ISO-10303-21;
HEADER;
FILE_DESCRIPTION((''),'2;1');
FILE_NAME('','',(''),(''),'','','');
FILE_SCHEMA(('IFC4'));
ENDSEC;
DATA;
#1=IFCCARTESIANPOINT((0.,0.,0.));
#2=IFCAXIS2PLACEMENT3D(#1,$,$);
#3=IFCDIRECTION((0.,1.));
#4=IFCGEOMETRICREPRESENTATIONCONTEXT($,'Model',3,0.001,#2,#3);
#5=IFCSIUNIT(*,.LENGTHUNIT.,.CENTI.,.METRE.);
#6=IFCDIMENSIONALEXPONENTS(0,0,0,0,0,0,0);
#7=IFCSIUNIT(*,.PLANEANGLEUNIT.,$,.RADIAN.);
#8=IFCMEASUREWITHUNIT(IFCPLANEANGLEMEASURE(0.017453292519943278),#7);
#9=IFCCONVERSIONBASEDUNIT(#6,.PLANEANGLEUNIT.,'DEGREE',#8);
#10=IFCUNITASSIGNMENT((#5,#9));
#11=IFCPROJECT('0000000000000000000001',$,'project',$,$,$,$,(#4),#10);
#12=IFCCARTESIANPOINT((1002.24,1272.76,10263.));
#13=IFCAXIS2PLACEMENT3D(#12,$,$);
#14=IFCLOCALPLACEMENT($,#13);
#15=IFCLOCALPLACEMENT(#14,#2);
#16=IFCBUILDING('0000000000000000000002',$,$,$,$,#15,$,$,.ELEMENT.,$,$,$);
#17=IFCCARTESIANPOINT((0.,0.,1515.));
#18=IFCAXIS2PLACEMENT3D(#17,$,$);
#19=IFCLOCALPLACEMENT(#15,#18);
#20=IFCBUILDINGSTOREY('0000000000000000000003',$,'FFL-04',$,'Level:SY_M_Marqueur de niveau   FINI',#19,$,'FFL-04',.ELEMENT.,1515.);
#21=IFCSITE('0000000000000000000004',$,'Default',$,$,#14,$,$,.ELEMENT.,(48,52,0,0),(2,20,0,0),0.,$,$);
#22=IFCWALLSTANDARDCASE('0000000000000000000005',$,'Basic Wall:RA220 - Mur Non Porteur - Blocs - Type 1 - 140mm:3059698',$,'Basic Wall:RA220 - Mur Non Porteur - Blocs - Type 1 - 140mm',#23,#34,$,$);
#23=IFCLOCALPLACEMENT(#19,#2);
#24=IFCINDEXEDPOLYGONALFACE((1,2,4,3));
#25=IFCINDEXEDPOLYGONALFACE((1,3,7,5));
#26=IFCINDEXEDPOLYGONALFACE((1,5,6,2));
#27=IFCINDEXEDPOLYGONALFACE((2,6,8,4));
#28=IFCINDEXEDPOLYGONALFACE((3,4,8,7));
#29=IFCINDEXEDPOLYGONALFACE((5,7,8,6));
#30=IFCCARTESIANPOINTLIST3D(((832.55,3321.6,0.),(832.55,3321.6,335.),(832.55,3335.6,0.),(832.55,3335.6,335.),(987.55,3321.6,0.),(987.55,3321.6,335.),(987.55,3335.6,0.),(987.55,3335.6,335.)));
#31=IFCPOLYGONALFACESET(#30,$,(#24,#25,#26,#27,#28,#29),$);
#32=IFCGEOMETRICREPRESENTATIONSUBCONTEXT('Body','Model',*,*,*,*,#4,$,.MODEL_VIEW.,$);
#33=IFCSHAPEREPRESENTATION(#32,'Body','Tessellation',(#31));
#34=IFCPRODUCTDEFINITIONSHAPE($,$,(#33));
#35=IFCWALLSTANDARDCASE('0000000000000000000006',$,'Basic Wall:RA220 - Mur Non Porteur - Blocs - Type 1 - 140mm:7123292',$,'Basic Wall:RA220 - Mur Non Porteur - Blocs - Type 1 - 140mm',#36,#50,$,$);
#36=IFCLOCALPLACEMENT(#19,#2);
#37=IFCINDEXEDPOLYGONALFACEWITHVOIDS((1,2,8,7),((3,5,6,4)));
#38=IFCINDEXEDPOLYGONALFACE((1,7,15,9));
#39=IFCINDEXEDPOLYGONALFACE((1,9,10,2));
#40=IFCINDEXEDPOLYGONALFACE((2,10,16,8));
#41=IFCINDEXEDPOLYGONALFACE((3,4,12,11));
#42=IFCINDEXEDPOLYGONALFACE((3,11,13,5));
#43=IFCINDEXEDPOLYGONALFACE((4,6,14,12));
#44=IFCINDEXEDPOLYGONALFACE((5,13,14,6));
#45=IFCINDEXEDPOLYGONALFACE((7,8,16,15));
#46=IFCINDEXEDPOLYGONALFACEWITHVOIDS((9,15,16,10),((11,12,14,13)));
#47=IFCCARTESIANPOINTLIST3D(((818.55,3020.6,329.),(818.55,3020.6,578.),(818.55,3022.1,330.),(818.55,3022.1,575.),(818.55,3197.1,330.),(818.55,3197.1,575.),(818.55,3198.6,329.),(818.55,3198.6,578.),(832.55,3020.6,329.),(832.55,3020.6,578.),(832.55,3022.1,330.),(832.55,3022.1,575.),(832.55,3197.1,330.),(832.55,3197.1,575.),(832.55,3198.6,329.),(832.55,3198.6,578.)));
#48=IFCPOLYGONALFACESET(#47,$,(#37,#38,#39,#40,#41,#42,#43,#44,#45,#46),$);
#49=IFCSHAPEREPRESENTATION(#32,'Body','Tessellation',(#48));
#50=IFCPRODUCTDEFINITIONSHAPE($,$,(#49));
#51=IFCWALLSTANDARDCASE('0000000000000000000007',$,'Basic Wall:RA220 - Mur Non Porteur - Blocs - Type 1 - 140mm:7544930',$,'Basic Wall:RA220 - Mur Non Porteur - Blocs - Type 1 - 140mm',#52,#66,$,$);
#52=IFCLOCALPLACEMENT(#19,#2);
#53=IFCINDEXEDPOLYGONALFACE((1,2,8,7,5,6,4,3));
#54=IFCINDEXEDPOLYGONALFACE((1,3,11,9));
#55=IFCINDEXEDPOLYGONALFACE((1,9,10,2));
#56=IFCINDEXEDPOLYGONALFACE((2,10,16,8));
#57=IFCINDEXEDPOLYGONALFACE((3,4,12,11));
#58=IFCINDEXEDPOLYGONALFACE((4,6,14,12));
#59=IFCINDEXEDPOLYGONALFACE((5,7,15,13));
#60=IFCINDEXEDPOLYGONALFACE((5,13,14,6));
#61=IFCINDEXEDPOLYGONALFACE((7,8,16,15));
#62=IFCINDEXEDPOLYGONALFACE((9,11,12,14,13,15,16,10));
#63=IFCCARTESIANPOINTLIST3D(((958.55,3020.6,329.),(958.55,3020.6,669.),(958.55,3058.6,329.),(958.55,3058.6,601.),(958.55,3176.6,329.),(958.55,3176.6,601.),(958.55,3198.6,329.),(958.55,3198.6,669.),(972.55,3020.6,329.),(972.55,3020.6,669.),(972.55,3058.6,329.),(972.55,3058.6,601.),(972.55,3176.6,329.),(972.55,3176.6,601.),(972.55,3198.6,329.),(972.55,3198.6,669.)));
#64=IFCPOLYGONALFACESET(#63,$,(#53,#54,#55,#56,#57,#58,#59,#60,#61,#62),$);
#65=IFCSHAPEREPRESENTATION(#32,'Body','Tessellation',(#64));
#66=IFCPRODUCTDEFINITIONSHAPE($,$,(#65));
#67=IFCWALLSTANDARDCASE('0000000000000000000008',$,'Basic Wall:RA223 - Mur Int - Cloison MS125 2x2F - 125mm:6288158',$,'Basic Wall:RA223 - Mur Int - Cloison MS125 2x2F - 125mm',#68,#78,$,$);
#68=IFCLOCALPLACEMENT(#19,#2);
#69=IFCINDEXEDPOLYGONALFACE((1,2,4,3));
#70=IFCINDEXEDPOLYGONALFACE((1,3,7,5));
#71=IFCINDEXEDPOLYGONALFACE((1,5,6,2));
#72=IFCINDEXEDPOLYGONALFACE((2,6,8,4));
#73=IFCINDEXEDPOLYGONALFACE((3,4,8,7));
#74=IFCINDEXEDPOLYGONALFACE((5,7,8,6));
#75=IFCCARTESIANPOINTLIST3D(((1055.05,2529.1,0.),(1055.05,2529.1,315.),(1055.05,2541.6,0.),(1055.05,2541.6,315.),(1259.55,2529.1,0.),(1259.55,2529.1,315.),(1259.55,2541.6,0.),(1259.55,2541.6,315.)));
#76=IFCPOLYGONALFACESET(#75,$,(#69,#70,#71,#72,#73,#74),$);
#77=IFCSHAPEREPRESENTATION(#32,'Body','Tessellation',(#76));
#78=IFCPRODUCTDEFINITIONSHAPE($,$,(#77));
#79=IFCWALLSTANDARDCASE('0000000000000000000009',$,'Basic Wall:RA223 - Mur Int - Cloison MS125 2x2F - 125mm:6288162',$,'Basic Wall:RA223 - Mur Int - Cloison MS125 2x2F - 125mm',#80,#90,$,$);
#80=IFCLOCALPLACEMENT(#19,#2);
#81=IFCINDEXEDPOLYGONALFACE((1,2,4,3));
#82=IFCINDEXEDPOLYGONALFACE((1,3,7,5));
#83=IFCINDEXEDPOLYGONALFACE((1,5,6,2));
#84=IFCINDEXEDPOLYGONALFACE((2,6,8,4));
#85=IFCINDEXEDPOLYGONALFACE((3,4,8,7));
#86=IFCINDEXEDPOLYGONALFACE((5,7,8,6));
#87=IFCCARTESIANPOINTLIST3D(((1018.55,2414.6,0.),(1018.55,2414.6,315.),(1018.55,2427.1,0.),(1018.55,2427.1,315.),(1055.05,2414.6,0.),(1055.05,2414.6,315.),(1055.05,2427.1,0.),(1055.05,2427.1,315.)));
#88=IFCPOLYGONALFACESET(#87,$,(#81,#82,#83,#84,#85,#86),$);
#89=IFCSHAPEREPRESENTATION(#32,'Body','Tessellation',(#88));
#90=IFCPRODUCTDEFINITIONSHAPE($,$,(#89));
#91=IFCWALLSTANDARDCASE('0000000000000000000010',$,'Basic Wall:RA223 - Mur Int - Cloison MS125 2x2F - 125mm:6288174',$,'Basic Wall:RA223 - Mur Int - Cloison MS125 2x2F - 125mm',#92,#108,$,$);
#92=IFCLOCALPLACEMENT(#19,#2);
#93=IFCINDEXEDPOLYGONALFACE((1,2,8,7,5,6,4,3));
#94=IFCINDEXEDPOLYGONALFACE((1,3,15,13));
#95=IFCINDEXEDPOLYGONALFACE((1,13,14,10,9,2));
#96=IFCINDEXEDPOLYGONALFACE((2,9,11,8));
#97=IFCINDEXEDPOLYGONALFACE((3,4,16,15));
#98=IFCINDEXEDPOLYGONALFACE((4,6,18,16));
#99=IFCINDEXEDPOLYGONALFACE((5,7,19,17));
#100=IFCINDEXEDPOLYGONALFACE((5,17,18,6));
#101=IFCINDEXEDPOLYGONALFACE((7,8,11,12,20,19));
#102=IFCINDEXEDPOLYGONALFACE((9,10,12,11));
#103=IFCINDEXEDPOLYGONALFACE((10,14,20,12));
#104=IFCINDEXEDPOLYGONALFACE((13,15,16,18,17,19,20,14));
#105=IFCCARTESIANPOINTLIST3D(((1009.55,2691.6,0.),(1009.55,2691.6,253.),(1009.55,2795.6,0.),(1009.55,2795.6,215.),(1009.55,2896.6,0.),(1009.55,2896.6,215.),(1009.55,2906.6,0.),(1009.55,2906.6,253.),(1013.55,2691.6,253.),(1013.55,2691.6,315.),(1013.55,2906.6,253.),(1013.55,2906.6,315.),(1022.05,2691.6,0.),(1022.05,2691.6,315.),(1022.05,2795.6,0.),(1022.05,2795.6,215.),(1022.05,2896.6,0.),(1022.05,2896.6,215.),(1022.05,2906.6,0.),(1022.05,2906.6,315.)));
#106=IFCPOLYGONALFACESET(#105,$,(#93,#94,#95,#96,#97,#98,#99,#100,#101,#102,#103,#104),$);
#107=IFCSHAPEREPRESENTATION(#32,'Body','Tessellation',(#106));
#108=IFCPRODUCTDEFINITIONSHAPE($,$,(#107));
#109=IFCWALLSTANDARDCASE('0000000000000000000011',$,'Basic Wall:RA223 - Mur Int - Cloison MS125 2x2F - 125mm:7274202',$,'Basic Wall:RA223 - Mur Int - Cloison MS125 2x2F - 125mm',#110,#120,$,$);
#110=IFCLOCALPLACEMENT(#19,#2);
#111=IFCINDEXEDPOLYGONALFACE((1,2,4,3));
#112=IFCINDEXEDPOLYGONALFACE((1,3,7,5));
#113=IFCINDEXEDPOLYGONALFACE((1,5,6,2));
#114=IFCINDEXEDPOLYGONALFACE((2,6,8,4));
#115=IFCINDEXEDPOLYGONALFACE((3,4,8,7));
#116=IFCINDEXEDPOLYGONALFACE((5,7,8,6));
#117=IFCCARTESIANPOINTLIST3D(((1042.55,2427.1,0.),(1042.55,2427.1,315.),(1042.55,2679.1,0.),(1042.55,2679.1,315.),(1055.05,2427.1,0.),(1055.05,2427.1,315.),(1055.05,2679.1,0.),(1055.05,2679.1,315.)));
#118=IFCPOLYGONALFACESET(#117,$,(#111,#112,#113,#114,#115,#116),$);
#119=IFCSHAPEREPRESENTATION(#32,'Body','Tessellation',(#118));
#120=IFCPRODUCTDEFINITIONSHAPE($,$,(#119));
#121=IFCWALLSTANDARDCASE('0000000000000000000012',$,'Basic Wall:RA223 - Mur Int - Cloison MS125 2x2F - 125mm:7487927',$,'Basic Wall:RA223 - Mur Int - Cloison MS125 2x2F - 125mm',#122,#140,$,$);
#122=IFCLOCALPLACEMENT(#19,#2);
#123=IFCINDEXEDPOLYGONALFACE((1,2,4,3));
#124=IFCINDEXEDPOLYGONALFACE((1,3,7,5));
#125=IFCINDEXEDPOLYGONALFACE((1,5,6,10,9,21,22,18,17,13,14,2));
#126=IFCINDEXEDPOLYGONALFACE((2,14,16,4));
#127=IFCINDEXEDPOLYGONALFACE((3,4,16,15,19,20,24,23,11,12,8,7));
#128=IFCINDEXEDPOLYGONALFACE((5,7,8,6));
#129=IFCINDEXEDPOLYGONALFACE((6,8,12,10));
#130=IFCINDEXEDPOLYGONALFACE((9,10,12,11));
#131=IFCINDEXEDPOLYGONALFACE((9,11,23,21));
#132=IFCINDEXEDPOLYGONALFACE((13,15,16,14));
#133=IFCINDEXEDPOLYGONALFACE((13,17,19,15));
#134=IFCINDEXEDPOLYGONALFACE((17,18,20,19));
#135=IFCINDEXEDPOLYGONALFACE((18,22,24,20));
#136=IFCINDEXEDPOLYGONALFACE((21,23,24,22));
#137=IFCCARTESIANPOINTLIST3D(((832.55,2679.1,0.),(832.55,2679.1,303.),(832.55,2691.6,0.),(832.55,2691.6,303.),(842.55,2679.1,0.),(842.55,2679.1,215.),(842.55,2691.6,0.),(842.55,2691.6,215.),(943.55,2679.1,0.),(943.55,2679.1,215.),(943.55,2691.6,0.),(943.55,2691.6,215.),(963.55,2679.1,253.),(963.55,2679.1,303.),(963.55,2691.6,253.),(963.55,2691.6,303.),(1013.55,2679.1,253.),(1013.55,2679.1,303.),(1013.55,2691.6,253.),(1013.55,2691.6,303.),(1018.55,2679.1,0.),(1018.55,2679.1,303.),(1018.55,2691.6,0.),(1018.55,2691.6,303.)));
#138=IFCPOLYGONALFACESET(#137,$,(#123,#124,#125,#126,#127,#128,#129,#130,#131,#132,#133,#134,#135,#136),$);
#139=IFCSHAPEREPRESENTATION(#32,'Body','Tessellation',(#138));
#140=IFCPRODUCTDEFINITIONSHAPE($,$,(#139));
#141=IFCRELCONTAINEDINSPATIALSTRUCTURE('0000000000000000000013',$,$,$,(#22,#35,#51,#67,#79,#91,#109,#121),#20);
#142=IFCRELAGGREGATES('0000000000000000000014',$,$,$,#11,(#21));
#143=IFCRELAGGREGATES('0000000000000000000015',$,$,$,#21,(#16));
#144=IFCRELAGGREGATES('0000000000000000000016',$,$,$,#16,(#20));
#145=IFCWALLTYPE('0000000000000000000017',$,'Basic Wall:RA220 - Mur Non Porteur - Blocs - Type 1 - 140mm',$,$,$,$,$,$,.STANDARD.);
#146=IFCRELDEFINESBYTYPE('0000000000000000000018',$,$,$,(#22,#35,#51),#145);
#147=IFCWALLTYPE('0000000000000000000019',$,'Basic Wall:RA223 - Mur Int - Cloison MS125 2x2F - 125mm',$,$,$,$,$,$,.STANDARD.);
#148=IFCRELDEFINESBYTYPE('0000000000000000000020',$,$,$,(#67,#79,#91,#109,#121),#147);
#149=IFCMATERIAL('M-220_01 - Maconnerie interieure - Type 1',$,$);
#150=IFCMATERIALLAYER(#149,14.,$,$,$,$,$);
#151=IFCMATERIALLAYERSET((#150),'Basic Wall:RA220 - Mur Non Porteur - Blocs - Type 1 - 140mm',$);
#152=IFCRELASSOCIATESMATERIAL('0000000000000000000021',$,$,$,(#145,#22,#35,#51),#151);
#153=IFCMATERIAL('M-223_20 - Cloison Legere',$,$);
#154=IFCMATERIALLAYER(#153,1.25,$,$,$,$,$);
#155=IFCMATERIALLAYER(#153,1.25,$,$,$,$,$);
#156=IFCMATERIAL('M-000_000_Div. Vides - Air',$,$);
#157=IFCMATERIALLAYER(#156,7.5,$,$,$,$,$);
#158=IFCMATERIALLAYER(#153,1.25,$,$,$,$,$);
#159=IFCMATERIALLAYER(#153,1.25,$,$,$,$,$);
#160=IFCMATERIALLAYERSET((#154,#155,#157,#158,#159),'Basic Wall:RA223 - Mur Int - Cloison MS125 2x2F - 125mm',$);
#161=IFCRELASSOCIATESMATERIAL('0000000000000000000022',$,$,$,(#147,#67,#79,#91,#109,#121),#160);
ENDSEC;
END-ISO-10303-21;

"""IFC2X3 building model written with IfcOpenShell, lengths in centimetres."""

from ifc_helpers import new_model, entity, si_unit, converted_unit, direction, frame, frame_2d, origin, place, context, subcontext, project, spatial, polyline, rectangle, extrude, clip, bounded_halfspace, material, layer, layer_set, layer_usage, type_object, element, save


model = new_model("IFC2X3")

# Units and contexts
model_context = context("Model", 3, precision=0.001, world=origin(), true_north=direction((0.0, 1.0)))
body_context = subcontext(model_context, "Body", "Model", "MODEL_VIEW")
ifc_project = project(units=[si_unit("LENGTHUNIT", "METRE", prefix="CENTI"), converted_unit("PLANEANGLEUNIT", "DEGREE", entity("IfcPlaneAngleMeasure", 0.017453292519943278), si_unit("PLANEANGLEUNIT", "RADIAN"), dimensions=[0, 0, 0, 0, 0, 0, 0])], contexts=[model_context])

# Site, building, storey
site_placement = place(None, frame((1002.24, 1272.76, 10263.0)))
site = spatial("IfcSite", under=ifc_project, at=site_placement, Name="Default", CompositionType="ELEMENT", RefLatitude=(48, 52, 0, 0), RefLongitude=(2, 20, 0, 0), RefElevation=0.0)
building_placement = place(site_placement, origin())
building = spatial("IfcBuilding", under=site, at=building_placement, CompositionType="ELEMENT")
storey_placement = place(building_placement, frame((0.0, 0.0, 1515.0)))
storey = spatial("IfcBuildingStorey", under=building, at=storey_placement, Name="FFL-04", ObjectType="Level:SY_M_Marqueur de niveau   FINI", LongName="FFL-04", CompositionType="ELEMENT", Elevation=1515.0)

# Wall
ifc_material_1 = material(Name="M-220_01 - Maconnerie interieure - Type 1")
ifc_layer_1 = layer(ifc_material_1, 14.0)
ifc_layer_set_1 = layer_set([ifc_layer_1], Name="Basic Wall:RA220 - Mur Non Porteur - Blocs - Type 1 - 140mm")
ifc_layer_usage_1 = layer_usage(ifc_layer_set_1, "AXIS2", "NEGATIVE", 7.0)
wall_type_1 = type_object("IfcWallType", Name="Basic Wall:RA220 - Mur Non Porteur - Blocs - Type 1 - 140mm", PredefinedType="STANDARD", material=ifc_layer_set_1)
wall_1_placement = place(storey_placement, frame((832.55, 3328.6, 0.0)))
element("IfcWallStandardCase", 1, at=wall_1_placement, inside=storey, type_object=wall_type_1, material=ifc_layer_usage_1, Name="Basic Wall:RA220 - Mur Non Porteur - Blocs - Type 1 - 140mm:3059698", ObjectType="Basic Wall:RA220 - Mur Non Porteur - Blocs - Type 1 - 140mm", context=body_context, shape_type="SweptSolid", body=[
    extrude(rectangle(XDim=154.99, YDim=14.0, at=frame_2d((77.5, 0.0), x_axis=(-1.0, 0.0))), origin(), (0.0, 0.0, 1.0), 335.0),
])

# Walls, openings
ifc_layer_usage_2 = layer_usage(ifc_layer_set_1, "AXIS2", "NEGATIVE", 7.0)
wall_2_placement = place(storey_placement, frame((825.55, 3198.6, 329.0), z_axis=(0.0, 0.0, 1.0), x_axis=(0.0, -1.0, 0.0)))
wall_2 = element("IfcWallStandardCase", 2, at=wall_2_placement, inside=storey, type_object=wall_type_1, material=ifc_layer_usage_2, Name="Basic Wall:RA220 - Mur Non Porteur - Blocs - Type 1 - 140mm:7123292", ObjectType="Basic Wall:RA220 - Mur Non Porteur - Blocs - Type 1 - 140mm", context=body_context, shape_type="Clipping", body=[
    clip(extrude(rectangle(XDim=178.0, YDim=14.0, at=frame_2d((89.0, 0.0), x_axis=(-1.0, 0.0))), origin(), (0.0, 0.0, 1.0), 249.0), bounded_halfspace(frame((178.0, -7.0, 0.0), z_axis=(0.0, 0.0, 1.0), x_axis=(0.0, -1.0, 0.0)), True, frame((178.0, -7.0, 0.0)), polyline([(0.0, 0.0), (0.0, 14.0), (-178.0, 14.0), (-178.0, 0.0), (0.0, 0.0)]))),
])
opening_1_placement = place(wall_2_placement, frame((3198.6, -825.55, 31.0), z_axis=(0.0, 0.0, 1.0), x_axis=(0.0, 1.0, 0.0)))
element("IfcOpeningElement", 3, at=opening_1_placement, cuts=wall_2, ObjectType="Opening", context=body_context, shape_type="SweptSolid", body=[
    extrude(rectangle(XDim=245.0, YDim=175.0, at=frame_2d((0.0, 0.0), x_axis=(1.0, 0.0))), frame((818.55, 3109.6, 92.5), z_axis=(1.0, 0.0, 0.0), x_axis=(0.0, 0.0, -1.0)), (0.0, 0.0, 1.0), 14.0),
])
ifc_layer_usage_3 = layer_usage(ifc_layer_set_1, "AXIS2", "POSITIVE", -7.0)
wall_3_placement = place(storey_placement, frame((965.55, 3198.6, 329.0), z_axis=(0.0, 0.0, 1.0), x_axis=(0.0, -1.0, 0.0)))
wall_3 = element("IfcWallStandardCase", 4, at=wall_3_placement, inside=storey, type_object=wall_type_1, material=ifc_layer_usage_3, Name="Basic Wall:RA220 - Mur Non Porteur - Blocs - Type 1 - 140mm:7544930", ObjectType="Basic Wall:RA220 - Mur Non Porteur - Blocs - Type 1 - 140mm", context=body_context, shape_type="SweptSolid", body=[
    extrude(rectangle(XDim=178.0, YDim=14.0, at=frame_2d((89.0, 0.0), x_axis=(-1.0, 0.0))), origin(), (0.0, 0.0, 1.0), 340.0),
])
opening_2_placement = place(wall_3_placement, frame((3198.6, -965.55, 31.0), z_axis=(0.0, 0.0, 1.0), x_axis=(0.0, 1.0, 0.0)))
element("IfcOpeningElement", 5, at=opening_2_placement, cuts=wall_3, ObjectType="Opening", context=body_context, shape_type="SweptSolid", body=[
    extrude(rectangle(XDim=272.0, YDim=118.0, at=frame_2d((0.0, 0.0), x_axis=(1.0, 0.0))), frame((958.55, 3117.6, 105.0), z_axis=(1.0, 0.0, 0.0), x_axis=(0.0, 0.0, -1.0)), (0.0, 0.0, 1.0), 14.0),
])

# Walls
ifc_material_2 = material(Name="M-223_20 - Cloison Legere")
ifc_layer_2 = layer(ifc_material_2, 1.25)
ifc_layer_3 = layer(ifc_material_2, 1.25)
ifc_material_3 = material(Name="M-000_000_Div. Vides - Air")
ifc_layer_4 = layer(ifc_material_3, 7.5)
ifc_layer_5 = layer(ifc_material_2, 1.25)
ifc_layer_6 = layer(ifc_material_2, 1.25)
ifc_layer_set_2 = layer_set([ifc_layer_2, ifc_layer_3, ifc_layer_4, ifc_layer_5, ifc_layer_6], Name="Basic Wall:RA223 - Mur Int - Cloison MS125 2x2F - 125mm")
ifc_layer_usage_4 = layer_usage(ifc_layer_set_2, "AXIS2", "NEGATIVE", 6.25)
wall_type_2 = type_object("IfcWallType", Name="Basic Wall:RA223 - Mur Int - Cloison MS125 2x2F - 125mm", PredefinedType="STANDARD", material=ifc_layer_set_2)
wall_4_placement = place(storey_placement, frame((1055.05, 2535.35, 0.0)))
element("IfcWallStandardCase", 6, at=wall_4_placement, inside=storey, type_object=wall_type_2, material=ifc_layer_usage_4, Name="Basic Wall:RA223 - Mur Int - Cloison MS125 2x2F - 125mm:6288158", ObjectType="Basic Wall:RA223 - Mur Int - Cloison MS125 2x2F - 125mm", context=body_context, shape_type="SweptSolid", body=[
    extrude(rectangle(XDim=204.49, YDim=12.5, at=frame_2d((102.25, 0.0), x_axis=(-1.0, 0.0))), origin(), (0.0, 0.0, 1.0), 315.0),
])
ifc_layer_usage_5 = layer_usage(ifc_layer_set_2, "AXIS2", "POSITIVE", -6.25)
wall_5_placement = place(storey_placement, frame((1055.05, 2420.85, 0.0), z_axis=(0.0, 0.0, 1.0), x_axis=(-1.0, 0.0, 0.0)))
element("IfcWallStandardCase", 7, at=wall_5_placement, inside=storey, type_object=wall_type_2, material=ifc_layer_usage_5, Name="Basic Wall:RA223 - Mur Int - Cloison MS125 2x2F - 125mm:6288162", ObjectType="Basic Wall:RA223 - Mur Int - Cloison MS125 2x2F - 125mm", context=body_context, shape_type="SweptSolid", body=[
    extrude(rectangle(XDim=36.51, YDim=12.5, at=frame_2d((18.25, 0.0), x_axis=(-1.0, 0.0))), origin(), (0.0, 0.0, 1.0), 315.0),
])

# Wall, opening
ifc_layer_usage_6 = layer_usage(ifc_layer_set_2, "AXIS2", "NEGATIVE", 6.25)
wall_6_placement = place(storey_placement, frame((1015.8, 2691.6, 0.0), z_axis=(0.0, 0.0, 1.0), x_axis=(0.0, 1.0, 0.0)))
wall_6 = element("IfcWallStandardCase", 8, at=wall_6_placement, inside=storey, type_object=wall_type_2, material=ifc_layer_usage_6, Name="Basic Wall:RA223 - Mur Int - Cloison MS125 2x2F - 125mm:6288174", ObjectType="Basic Wall:RA223 - Mur Int - Cloison MS125 2x2F - 125mm", context=body_context, shape_type="Clipping", body=[
    clip(clip(extrude(rectangle(XDim=215.0, YDim=12.5, at=frame_2d((107.5, 0.0), x_axis=(-1.0, 0.0))), origin(), (0.0, 0.0, 1.0), 315.0), bounded_halfspace(frame((0.0, 2.26, 253.0), z_axis=(0.0, 0.0, -1.0), x_axis=(1.0, 0.0, 0.0)), True, frame((0.0, 2.26, 253.0), z_axis=(0.0, 0.0, -1.0), x_axis=(1.0, 0.0, 0.0)), polyline([(0.0, 0.0), (0.0, -3.99), (215.0, -3.99), (215.0, 0.0), (0.0, 0.0)]))), bounded_halfspace(frame((215.0, 2.26, 253.0), z_axis=(0.0, -1.0, 0.0), x_axis=(1.0, 0.0, 0.0)), True, frame((215.0, 2.26, 253.0), z_axis=(0.0, -1.0, 0.0), x_axis=(1.0, 0.0, 0.0)), polyline([(0.0, 0.0), (0.0, 62.0), (-215.0, 62.0), (-215.0, 50.0), (-215.0, 0.0), (0.0, 0.0)]))),
])
opening_3_placement = place(wall_6_placement, frame((-2691.6, 1015.8, 0.0), z_axis=(0.0, 0.0, 1.0), x_axis=(0.0, -1.0, 0.0)))
element("IfcOpeningElement", 9, at=opening_3_placement, cuts=wall_6, ObjectType="Opening", context=body_context, shape_type="SweptSolid", body=[
    extrude(rectangle(XDim=240.0, YDim=101.0, at=frame_2d((0.0, 0.0), x_axis=(0.0, 1.0))), frame((1023.05, 2846.1, 95.0), z_axis=(-1.0, 0.0, 0.0), x_axis=(0.0, 1.0, 0.0)), (0.0, 0.0, 1.0), 13.5),
])

# Wall
ifc_layer_usage_7 = layer_usage(ifc_layer_set_2, "AXIS2", "NEGATIVE", 6.25)
wall_7_placement = place(storey_placement, frame((1048.8, 2427.1, 0.0), z_axis=(0.0, 0.0, 1.0), x_axis=(0.0, 1.0, 0.0)))
element("IfcWallStandardCase", 10, at=wall_7_placement, inside=storey, type_object=wall_type_2, material=ifc_layer_usage_7, Name="Basic Wall:RA223 - Mur Int - Cloison MS125 2x2F - 125mm:7274202", ObjectType="Basic Wall:RA223 - Mur Int - Cloison MS125 2x2F - 125mm", context=body_context, shape_type="SweptSolid", body=[
    extrude(rectangle(XDim=252.0, YDim=12.5, at=frame_2d((126.0, 0.0), x_axis=(-1.0, 0.0))), origin(), (0.0, 0.0, 1.0), 315.0),
])

# Wall, opening
ifc_layer_usage_8 = layer_usage(ifc_layer_set_2, "AXIS2", "POSITIVE", -6.25)
wall_8_placement = place(storey_placement, frame((1018.55, 2685.35, 0.0), z_axis=(0.0, 0.0, 1.0), x_axis=(-1.0, 0.0, 0.0)))
wall_8 = element("IfcWallStandardCase", 11, at=wall_8_placement, inside=storey, type_object=wall_type_2, material=ifc_layer_usage_8, Name="Basic Wall:RA223 - Mur Int - Cloison MS125 2x2F - 125mm:7487927", ObjectType="Basic Wall:RA223 - Mur Int - Cloison MS125 2x2F - 125mm", context=body_context, shape_type="Clipping", body=[
    clip(extrude(rectangle(XDim=185.99, YDim=12.5, at=frame_2d((93.0, 0.0), x_axis=(1.0, 0.0))), origin(), (0.0, 0.0, 1.0), 303.0), bounded_halfspace(frame((55.0, -6.25, 253.0), z_axis=(0.0, 0.0, -1.0), x_axis=(0.0, -1.0, 0.0)), True, frame((55.0, -6.25, 253.0), z_axis=(0.0, 0.0, -1.0), x_axis=(0.0, -1.0, 0.0)), polyline([(0.0, 0.0), (0.0, 46.01), (0.0, 50.0), (-12.5, 50.0), (-12.5, 0.0), (0.0, 0.0)]))),
])
opening_4_placement = place(wall_8_placement, frame((1018.55, 2685.35, 0.0), z_axis=(0.0, 0.0, 1.0), x_axis=(-1.0, 0.0, 0.0)))
element("IfcOpeningElement", 12, at=opening_4_placement, cuts=wall_8, ObjectType="Opening", context=body_context, shape_type="SweptSolid", body=[
    extrude(rectangle(XDim=240.0, YDim=101.0, at=frame_2d((0.0, 0.0), x_axis=(0.0, 1.0))), frame((893.05, 2691.6, 95.0), z_axis=(0.0, -1.0, 0.0), x_axis=(-1.0, 0.0, 0.0)), (0.0, 0.0, 1.0), 13.5),
])

save(model, "model.ifc")
